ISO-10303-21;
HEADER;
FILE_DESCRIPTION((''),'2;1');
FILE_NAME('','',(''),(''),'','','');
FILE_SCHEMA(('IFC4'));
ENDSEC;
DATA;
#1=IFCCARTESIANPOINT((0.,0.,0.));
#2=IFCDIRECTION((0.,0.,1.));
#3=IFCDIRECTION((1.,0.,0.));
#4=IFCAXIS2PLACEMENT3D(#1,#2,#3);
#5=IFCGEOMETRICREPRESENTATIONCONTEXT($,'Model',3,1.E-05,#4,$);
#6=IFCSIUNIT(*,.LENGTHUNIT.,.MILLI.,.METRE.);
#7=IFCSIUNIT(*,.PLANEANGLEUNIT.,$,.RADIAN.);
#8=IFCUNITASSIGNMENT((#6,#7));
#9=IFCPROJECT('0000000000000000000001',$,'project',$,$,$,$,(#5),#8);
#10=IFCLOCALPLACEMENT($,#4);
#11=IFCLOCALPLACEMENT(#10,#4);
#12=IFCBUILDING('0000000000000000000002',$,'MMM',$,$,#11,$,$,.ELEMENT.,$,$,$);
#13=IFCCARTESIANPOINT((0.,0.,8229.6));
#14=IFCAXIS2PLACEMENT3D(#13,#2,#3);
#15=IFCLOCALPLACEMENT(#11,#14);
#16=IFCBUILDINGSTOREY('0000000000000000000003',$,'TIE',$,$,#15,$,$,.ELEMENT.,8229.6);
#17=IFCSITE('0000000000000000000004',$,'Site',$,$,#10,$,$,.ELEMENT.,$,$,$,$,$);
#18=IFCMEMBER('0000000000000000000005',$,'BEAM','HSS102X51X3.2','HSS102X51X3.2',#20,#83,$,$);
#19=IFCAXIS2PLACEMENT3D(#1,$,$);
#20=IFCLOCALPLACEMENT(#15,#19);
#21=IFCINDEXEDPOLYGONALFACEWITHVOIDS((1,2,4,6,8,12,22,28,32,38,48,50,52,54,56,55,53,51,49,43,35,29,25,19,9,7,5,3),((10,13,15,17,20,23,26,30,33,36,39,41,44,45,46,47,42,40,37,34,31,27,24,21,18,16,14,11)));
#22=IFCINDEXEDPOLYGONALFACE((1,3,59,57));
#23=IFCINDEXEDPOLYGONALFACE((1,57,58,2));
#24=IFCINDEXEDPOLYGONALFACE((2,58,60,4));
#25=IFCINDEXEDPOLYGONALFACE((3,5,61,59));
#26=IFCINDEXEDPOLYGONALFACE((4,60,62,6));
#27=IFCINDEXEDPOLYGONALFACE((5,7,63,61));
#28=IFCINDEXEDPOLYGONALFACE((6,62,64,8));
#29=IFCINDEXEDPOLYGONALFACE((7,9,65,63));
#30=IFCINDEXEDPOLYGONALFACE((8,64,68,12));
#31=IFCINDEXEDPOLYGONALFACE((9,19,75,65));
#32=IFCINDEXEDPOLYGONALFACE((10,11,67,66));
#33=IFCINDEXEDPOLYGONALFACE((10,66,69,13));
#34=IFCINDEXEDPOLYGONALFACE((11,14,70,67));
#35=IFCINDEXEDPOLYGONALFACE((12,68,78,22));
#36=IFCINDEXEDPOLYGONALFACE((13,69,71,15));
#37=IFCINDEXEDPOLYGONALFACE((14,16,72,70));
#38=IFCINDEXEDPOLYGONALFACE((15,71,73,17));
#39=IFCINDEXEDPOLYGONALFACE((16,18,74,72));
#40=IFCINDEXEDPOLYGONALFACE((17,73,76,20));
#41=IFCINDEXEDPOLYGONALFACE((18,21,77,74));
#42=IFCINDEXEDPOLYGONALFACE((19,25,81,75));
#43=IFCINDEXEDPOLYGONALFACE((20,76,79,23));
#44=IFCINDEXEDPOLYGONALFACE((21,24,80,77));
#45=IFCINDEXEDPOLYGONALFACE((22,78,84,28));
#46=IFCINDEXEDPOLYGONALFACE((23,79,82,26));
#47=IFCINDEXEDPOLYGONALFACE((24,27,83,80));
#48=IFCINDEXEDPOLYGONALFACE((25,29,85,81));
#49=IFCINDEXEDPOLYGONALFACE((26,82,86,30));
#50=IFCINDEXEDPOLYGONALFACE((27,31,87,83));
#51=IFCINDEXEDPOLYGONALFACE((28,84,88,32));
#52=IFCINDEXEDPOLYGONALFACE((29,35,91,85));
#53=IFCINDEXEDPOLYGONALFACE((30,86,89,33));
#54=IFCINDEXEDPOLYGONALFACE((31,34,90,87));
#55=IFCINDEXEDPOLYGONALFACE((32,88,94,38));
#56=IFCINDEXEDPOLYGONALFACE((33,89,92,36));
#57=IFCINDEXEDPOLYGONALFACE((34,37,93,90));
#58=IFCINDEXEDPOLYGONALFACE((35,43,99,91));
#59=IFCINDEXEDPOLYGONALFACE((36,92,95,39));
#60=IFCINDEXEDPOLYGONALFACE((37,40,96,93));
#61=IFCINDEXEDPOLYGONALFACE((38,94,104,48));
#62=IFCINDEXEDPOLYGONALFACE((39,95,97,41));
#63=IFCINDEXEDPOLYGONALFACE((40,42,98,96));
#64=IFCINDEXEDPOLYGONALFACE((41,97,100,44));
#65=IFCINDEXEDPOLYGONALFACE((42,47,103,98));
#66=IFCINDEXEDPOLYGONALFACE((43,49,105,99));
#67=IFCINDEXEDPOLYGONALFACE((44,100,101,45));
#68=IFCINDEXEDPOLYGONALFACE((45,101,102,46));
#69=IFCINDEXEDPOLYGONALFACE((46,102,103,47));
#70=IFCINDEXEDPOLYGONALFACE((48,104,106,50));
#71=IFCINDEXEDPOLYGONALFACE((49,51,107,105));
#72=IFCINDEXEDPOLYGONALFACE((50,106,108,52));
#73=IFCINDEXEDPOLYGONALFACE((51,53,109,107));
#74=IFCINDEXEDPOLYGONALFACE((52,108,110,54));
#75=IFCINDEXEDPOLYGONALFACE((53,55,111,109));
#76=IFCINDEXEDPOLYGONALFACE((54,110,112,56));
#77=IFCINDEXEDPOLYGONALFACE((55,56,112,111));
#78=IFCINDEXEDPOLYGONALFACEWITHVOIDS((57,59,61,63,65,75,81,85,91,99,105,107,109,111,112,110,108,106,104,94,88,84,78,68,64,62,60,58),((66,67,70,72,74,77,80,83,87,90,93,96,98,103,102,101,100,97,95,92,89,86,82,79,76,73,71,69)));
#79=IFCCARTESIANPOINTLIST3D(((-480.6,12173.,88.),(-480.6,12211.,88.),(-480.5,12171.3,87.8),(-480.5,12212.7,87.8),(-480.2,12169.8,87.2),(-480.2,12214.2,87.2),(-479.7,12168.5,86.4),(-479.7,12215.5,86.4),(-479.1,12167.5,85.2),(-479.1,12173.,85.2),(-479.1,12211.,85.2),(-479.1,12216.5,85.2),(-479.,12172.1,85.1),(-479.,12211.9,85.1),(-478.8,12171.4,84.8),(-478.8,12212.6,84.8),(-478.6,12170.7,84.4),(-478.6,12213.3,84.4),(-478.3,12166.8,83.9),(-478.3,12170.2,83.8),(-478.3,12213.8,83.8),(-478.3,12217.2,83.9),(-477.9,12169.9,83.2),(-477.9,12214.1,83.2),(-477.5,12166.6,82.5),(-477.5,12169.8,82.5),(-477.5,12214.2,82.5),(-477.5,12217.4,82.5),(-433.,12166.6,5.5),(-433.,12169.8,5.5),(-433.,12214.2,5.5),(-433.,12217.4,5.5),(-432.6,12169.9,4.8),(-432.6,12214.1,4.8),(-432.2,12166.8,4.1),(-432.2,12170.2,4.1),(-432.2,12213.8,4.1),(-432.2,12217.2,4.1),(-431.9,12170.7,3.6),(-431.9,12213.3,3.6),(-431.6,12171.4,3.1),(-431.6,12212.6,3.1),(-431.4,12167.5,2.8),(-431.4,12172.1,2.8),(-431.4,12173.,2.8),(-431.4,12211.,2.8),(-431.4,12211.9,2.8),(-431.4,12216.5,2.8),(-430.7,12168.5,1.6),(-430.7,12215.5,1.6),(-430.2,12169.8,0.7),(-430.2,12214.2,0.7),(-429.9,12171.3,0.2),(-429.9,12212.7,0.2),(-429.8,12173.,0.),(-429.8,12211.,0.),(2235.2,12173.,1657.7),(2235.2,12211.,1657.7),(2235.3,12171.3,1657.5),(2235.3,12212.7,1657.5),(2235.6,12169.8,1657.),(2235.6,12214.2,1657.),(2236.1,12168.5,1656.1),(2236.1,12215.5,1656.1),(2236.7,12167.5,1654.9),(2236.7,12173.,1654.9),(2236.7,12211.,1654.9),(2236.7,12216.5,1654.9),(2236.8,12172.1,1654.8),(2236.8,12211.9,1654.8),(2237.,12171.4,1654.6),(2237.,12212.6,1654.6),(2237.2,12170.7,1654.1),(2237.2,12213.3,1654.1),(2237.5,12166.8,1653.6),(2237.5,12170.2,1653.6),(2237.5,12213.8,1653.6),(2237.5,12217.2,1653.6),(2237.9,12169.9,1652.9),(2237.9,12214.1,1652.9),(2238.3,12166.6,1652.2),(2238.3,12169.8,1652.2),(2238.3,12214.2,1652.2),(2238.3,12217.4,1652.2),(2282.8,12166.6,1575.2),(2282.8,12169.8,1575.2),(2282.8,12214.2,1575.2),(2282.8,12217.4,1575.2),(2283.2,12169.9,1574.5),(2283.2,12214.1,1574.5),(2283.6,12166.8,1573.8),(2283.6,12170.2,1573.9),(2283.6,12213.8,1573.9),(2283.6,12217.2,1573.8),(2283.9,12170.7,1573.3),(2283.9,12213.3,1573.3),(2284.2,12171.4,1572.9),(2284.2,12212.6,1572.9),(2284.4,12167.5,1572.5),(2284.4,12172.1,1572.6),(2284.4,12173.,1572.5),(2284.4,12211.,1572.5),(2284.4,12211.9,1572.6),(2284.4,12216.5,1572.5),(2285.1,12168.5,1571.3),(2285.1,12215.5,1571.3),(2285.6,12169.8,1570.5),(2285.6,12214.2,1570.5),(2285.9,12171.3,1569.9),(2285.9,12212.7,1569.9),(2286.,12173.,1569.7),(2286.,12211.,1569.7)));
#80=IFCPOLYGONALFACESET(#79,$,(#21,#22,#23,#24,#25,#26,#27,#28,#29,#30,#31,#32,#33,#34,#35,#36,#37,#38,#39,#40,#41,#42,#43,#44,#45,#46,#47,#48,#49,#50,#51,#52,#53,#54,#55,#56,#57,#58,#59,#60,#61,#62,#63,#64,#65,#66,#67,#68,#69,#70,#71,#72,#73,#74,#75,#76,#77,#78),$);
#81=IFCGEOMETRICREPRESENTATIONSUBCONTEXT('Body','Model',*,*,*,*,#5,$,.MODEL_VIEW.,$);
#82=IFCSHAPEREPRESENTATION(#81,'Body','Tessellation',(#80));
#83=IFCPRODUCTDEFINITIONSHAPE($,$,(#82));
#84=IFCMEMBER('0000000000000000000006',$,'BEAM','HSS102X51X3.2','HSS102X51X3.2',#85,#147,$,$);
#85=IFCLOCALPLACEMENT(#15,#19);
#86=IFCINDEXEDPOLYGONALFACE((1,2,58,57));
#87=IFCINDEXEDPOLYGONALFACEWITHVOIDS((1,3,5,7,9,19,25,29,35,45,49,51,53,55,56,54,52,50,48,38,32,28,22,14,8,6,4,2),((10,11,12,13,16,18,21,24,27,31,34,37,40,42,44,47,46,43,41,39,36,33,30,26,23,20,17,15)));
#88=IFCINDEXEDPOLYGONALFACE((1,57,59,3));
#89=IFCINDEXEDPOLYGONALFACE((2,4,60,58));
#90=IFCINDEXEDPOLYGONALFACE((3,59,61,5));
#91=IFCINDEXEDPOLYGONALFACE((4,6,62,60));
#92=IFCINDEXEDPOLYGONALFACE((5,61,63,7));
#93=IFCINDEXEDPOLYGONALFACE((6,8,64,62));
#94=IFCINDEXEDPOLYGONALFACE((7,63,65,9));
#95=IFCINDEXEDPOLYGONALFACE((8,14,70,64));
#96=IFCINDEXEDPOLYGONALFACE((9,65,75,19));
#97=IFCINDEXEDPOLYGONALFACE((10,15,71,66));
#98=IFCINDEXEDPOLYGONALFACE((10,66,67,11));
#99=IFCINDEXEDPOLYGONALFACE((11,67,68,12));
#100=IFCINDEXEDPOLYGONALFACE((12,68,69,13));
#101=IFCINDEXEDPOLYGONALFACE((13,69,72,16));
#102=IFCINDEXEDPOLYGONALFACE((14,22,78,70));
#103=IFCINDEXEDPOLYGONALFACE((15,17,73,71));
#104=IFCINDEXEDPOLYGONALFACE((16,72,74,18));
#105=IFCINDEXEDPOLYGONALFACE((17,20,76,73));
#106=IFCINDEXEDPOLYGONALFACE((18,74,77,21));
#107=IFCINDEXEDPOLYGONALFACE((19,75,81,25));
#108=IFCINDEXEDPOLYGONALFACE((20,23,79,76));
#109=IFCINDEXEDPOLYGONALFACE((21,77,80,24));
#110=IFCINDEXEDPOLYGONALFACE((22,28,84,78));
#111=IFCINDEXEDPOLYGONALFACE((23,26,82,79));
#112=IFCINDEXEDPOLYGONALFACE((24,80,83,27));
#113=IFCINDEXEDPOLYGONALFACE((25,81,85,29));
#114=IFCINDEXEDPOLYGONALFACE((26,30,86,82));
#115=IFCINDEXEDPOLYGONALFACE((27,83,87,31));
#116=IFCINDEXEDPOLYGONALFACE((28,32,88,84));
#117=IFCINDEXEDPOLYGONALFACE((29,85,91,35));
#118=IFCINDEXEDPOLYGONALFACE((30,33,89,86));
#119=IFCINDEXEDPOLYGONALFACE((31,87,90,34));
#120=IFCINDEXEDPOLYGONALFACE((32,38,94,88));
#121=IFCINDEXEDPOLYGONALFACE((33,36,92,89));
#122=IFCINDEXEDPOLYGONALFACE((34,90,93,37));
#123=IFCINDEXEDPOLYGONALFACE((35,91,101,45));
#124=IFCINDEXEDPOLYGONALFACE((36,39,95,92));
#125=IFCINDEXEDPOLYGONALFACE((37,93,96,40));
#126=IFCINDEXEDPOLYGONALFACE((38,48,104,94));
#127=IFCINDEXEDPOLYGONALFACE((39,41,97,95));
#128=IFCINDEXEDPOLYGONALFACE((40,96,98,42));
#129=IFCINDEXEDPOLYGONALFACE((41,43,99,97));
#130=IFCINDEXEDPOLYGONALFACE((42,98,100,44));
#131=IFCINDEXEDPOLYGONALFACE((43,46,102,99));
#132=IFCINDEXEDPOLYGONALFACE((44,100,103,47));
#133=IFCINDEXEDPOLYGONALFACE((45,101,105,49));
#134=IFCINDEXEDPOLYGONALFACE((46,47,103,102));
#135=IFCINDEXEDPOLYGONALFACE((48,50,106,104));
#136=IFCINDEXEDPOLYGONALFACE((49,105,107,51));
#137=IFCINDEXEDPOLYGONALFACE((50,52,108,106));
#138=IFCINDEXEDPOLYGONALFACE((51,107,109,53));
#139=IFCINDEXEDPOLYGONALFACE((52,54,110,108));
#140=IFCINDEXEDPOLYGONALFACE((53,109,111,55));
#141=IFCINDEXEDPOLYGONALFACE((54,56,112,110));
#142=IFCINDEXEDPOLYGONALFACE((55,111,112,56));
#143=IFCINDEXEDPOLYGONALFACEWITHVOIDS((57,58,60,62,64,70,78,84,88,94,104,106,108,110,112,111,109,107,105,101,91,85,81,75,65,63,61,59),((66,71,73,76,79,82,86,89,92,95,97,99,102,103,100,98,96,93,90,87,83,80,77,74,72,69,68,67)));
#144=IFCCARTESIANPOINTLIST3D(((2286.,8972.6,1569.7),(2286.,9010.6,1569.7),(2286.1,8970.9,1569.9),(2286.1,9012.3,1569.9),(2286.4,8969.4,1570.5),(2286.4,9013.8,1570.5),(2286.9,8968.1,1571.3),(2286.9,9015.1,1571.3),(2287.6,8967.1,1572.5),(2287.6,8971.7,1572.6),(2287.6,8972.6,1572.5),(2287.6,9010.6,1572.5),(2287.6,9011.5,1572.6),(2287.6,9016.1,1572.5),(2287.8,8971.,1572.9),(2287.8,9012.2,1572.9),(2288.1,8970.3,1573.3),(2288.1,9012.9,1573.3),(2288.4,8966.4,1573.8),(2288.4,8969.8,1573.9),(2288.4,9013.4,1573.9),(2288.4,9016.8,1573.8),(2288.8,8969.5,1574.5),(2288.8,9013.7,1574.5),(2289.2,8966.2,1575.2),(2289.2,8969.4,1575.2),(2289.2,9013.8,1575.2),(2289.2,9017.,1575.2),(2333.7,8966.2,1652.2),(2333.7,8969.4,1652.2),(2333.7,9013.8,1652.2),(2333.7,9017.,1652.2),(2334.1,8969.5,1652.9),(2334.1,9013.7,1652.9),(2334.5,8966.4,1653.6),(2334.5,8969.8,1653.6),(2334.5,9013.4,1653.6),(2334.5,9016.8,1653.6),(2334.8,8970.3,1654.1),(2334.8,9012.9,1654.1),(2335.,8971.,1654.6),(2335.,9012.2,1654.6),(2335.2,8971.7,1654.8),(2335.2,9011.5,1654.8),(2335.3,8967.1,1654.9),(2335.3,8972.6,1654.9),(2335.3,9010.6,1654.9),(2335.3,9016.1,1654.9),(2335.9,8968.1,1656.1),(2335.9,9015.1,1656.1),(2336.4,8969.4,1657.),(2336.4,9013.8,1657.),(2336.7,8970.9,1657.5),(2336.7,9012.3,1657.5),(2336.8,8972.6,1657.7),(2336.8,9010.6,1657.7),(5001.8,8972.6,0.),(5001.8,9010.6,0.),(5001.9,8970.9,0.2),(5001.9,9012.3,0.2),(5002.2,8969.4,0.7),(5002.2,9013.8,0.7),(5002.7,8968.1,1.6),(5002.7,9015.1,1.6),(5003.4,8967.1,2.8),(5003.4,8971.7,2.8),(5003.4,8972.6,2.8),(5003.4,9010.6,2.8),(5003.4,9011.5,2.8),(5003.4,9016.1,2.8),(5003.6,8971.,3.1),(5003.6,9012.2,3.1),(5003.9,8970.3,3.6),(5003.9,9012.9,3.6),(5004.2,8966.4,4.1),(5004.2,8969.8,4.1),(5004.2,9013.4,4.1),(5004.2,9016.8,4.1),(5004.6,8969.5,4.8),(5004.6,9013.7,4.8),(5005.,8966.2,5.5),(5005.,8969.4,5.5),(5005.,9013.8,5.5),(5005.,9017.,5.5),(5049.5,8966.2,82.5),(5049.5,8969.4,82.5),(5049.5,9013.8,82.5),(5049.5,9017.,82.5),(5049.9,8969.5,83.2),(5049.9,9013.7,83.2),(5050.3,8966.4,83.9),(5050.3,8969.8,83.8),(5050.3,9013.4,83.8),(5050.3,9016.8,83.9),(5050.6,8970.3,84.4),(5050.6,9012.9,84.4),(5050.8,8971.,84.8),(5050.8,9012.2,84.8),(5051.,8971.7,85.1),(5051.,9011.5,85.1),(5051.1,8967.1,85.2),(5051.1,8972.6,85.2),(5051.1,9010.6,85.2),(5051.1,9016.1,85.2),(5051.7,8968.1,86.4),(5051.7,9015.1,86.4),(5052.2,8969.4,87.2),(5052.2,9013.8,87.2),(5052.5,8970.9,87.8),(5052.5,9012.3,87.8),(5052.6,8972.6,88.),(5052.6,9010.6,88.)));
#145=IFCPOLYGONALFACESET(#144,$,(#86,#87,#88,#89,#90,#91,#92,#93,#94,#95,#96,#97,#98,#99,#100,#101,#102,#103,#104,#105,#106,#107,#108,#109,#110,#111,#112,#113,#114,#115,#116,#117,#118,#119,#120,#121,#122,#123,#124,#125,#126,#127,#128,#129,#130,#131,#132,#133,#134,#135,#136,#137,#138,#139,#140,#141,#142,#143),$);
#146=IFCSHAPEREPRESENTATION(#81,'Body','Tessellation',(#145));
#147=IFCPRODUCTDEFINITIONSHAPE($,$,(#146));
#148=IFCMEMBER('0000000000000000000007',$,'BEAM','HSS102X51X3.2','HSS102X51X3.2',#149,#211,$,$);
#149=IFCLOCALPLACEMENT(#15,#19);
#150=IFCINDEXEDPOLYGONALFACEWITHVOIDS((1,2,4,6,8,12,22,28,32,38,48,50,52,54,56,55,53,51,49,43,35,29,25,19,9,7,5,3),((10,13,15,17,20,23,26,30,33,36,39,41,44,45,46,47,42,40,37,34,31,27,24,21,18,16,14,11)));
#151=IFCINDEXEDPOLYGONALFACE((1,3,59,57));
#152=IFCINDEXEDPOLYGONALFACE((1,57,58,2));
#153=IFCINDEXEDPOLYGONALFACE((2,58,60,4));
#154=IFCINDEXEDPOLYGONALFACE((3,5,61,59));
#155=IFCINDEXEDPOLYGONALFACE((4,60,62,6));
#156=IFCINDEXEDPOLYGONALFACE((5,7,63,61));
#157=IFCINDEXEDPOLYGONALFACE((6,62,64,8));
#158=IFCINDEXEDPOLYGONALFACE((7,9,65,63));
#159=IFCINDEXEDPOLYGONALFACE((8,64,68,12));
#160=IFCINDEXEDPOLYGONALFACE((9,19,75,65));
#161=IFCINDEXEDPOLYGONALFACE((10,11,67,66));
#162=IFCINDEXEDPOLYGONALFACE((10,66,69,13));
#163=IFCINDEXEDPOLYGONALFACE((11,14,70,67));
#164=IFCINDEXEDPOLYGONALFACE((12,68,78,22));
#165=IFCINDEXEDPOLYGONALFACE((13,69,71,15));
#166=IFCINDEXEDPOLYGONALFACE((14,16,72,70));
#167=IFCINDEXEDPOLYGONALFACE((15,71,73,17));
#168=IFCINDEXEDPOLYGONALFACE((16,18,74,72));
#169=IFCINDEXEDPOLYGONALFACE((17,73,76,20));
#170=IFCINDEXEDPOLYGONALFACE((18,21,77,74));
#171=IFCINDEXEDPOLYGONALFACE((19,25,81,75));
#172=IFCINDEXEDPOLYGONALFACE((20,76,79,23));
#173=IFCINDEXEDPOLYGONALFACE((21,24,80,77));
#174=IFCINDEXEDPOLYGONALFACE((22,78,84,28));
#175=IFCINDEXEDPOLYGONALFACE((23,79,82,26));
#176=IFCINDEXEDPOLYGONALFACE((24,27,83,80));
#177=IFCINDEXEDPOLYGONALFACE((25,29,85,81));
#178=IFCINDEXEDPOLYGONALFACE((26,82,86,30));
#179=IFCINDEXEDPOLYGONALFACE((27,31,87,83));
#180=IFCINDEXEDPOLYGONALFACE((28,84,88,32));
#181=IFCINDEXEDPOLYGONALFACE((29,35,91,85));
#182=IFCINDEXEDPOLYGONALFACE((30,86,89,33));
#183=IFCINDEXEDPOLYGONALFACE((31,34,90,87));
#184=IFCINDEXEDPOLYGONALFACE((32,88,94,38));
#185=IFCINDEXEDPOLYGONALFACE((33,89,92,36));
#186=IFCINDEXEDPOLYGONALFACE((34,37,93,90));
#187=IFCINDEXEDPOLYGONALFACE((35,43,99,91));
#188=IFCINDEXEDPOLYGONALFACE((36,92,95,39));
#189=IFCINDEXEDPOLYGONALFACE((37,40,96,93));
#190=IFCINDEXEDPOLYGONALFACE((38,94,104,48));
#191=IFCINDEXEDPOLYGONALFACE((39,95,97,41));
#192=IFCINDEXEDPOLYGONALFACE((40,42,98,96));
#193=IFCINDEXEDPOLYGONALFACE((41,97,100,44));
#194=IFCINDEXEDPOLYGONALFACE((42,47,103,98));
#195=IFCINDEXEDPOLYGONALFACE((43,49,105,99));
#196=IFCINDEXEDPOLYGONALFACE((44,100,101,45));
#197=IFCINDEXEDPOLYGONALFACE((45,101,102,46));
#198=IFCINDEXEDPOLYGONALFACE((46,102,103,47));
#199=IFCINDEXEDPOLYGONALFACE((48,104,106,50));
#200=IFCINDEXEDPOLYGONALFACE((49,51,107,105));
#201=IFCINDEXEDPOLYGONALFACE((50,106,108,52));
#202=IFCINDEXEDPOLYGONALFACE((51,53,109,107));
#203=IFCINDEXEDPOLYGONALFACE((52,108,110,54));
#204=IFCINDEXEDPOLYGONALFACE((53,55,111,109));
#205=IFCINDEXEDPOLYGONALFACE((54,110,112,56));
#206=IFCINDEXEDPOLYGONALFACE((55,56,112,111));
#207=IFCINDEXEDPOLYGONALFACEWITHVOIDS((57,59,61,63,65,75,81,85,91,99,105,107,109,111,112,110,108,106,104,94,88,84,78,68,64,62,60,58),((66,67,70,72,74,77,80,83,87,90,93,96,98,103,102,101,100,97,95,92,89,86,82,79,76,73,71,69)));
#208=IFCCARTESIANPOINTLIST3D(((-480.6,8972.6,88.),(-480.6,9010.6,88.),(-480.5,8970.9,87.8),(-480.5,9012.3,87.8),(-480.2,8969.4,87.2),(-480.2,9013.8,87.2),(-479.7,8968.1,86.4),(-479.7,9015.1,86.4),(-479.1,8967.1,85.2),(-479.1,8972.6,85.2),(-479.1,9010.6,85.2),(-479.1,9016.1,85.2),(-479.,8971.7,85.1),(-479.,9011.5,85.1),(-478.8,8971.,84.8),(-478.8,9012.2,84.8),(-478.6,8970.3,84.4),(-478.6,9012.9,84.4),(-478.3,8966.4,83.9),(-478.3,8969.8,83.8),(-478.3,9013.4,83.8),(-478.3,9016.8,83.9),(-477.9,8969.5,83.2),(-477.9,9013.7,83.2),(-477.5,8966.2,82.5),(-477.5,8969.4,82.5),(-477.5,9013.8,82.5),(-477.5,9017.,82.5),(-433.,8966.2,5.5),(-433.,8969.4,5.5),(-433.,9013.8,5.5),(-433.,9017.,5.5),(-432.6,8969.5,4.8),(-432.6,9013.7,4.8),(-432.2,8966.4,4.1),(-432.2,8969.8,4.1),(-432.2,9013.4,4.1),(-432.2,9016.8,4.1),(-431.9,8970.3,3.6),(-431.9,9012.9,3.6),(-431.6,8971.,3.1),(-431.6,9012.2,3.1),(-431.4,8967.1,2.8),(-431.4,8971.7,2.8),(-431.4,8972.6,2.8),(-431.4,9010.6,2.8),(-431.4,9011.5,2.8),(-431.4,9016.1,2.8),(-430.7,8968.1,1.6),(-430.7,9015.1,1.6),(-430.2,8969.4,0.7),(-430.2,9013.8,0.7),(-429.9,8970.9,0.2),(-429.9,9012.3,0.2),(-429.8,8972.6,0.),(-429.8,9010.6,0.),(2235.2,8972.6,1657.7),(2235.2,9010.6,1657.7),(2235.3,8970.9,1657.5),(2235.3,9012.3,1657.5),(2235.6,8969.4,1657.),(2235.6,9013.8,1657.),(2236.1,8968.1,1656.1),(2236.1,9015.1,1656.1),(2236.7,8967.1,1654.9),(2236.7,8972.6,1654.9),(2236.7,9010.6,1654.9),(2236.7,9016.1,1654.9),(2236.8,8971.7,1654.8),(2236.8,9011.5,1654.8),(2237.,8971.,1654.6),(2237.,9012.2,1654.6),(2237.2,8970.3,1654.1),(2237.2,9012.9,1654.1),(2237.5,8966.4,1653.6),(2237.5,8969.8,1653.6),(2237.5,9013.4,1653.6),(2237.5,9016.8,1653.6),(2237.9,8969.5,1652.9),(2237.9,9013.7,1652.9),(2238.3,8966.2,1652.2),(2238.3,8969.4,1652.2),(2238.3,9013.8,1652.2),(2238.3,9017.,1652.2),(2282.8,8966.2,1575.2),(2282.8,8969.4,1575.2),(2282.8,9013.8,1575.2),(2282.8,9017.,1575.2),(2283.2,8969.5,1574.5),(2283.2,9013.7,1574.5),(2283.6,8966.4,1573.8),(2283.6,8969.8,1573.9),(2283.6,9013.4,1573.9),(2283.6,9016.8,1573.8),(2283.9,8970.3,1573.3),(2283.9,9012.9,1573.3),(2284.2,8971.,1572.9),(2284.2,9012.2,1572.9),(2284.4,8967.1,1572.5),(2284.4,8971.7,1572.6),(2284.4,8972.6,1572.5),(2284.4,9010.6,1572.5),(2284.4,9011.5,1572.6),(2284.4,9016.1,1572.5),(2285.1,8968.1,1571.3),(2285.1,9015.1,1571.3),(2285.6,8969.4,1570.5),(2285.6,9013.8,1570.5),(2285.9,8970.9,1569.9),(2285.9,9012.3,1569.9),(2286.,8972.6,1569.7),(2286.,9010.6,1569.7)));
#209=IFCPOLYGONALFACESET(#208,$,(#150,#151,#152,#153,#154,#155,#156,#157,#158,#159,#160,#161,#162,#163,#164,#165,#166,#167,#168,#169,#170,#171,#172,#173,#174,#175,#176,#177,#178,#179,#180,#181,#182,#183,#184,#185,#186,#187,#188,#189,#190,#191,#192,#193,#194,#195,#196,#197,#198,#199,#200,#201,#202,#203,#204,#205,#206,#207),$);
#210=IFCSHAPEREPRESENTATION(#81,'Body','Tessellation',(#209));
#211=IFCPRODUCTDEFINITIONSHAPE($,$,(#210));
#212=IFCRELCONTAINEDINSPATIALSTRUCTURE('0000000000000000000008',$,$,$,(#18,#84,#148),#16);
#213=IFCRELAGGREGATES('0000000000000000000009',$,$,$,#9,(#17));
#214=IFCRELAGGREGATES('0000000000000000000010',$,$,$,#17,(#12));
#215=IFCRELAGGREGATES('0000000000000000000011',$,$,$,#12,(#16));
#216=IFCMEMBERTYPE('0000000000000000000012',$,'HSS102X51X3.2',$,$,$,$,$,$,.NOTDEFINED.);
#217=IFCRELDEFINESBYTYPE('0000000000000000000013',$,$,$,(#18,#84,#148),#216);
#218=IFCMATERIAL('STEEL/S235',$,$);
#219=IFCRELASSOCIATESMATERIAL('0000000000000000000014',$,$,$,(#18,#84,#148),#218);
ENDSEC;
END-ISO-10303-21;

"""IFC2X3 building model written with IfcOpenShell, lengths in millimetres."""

from ifc_helpers import new_model, si_unit, frame, origin_with_axes, origin_2d_with_axis, place, context, subcontext, project, spatial, hollow_rectangle, extrude, material, type_object, element, save


model = new_model("IFC2X3")

# Units and contexts
model_context = context("Model", 3, precision=1e-05, world=origin_with_axes())
body_context = subcontext(model_context, "Body", "Model", "MODEL_VIEW")
ifc_project = project(units=[si_unit("LENGTHUNIT", "METRE", prefix="MILLI"), si_unit("PLANEANGLEUNIT", "RADIAN")], contexts=[model_context])

# Site, building, storey
site_placement = place(None, origin_with_axes())
site = spatial("IfcSite", under=ifc_project, at=site_placement, Name="Site", CompositionType="ELEMENT")
building_placement = place(site_placement, origin_with_axes())
building = spatial("IfcBuilding", under=site, at=building_placement, Name="MMM", CompositionType="ELEMENT")
storey_placement = place(building_placement, frame((0.0, 0.0, 8229.6), z_axis=(0.0, 0.0, 1.0), x_axis=(1.0, 0.0, 0.0)))
storey = spatial("IfcBuildingStorey", under=building, at=storey_placement, Name="TIE", CompositionType="ELEMENT", Elevation=8229.6)

# Shared definitions
ifc_material = material(Name="STEEL/S235")

# Members
member_type_1 = type_object("IfcMemberType", Name="HSS102X51X3.2", PredefinedType="NOTDEFINED")
for number, where, z_axis, x_axis, name in (
    (1, (2260.6, 12192.0, 1613.7), (-0.500422, 0.0, 0.865782), (-0.865782, 0.0, -0.500422), "BEAM"),
    (2, (2311.4, 8991.6, 1613.7), (0.500422, 0.0, 0.865782), (0.865782, 0.0, -0.500422), "BEAM"),
    (3, (2260.6, 8991.6, 1613.7), (-0.500422, 0.0, 0.865782), (-0.865782, 0.0, -0.500422), "BEAM"),
):
    element("IfcMember", number, at=place(storey_placement, frame(where, z_axis=z_axis, x_axis=x_axis)), inside=storey, type_object=member_type_1, material=ifc_material, Name=name, Description="HSS102X51X3.2", ObjectType="HSS102X51X3.2", context=body_context, shape_type="SweptSolid", body=[
        extrude(hollow_rectangle(XDim=50.8, YDim=101.6, WallThickness=3.2, InnerFilletRadius=3.2, OuterFilletRadius=6.4, at=origin_2d_with_axis()), frame((3136.8, 0.0, 0.0), z_axis=(-1.0, 0.0, 0.0), x_axis=(0.0, -1.0, 0.0)), (0.0, 0.0, 1.0), 3136.8),
    ])

save(model, "model.ifc")
